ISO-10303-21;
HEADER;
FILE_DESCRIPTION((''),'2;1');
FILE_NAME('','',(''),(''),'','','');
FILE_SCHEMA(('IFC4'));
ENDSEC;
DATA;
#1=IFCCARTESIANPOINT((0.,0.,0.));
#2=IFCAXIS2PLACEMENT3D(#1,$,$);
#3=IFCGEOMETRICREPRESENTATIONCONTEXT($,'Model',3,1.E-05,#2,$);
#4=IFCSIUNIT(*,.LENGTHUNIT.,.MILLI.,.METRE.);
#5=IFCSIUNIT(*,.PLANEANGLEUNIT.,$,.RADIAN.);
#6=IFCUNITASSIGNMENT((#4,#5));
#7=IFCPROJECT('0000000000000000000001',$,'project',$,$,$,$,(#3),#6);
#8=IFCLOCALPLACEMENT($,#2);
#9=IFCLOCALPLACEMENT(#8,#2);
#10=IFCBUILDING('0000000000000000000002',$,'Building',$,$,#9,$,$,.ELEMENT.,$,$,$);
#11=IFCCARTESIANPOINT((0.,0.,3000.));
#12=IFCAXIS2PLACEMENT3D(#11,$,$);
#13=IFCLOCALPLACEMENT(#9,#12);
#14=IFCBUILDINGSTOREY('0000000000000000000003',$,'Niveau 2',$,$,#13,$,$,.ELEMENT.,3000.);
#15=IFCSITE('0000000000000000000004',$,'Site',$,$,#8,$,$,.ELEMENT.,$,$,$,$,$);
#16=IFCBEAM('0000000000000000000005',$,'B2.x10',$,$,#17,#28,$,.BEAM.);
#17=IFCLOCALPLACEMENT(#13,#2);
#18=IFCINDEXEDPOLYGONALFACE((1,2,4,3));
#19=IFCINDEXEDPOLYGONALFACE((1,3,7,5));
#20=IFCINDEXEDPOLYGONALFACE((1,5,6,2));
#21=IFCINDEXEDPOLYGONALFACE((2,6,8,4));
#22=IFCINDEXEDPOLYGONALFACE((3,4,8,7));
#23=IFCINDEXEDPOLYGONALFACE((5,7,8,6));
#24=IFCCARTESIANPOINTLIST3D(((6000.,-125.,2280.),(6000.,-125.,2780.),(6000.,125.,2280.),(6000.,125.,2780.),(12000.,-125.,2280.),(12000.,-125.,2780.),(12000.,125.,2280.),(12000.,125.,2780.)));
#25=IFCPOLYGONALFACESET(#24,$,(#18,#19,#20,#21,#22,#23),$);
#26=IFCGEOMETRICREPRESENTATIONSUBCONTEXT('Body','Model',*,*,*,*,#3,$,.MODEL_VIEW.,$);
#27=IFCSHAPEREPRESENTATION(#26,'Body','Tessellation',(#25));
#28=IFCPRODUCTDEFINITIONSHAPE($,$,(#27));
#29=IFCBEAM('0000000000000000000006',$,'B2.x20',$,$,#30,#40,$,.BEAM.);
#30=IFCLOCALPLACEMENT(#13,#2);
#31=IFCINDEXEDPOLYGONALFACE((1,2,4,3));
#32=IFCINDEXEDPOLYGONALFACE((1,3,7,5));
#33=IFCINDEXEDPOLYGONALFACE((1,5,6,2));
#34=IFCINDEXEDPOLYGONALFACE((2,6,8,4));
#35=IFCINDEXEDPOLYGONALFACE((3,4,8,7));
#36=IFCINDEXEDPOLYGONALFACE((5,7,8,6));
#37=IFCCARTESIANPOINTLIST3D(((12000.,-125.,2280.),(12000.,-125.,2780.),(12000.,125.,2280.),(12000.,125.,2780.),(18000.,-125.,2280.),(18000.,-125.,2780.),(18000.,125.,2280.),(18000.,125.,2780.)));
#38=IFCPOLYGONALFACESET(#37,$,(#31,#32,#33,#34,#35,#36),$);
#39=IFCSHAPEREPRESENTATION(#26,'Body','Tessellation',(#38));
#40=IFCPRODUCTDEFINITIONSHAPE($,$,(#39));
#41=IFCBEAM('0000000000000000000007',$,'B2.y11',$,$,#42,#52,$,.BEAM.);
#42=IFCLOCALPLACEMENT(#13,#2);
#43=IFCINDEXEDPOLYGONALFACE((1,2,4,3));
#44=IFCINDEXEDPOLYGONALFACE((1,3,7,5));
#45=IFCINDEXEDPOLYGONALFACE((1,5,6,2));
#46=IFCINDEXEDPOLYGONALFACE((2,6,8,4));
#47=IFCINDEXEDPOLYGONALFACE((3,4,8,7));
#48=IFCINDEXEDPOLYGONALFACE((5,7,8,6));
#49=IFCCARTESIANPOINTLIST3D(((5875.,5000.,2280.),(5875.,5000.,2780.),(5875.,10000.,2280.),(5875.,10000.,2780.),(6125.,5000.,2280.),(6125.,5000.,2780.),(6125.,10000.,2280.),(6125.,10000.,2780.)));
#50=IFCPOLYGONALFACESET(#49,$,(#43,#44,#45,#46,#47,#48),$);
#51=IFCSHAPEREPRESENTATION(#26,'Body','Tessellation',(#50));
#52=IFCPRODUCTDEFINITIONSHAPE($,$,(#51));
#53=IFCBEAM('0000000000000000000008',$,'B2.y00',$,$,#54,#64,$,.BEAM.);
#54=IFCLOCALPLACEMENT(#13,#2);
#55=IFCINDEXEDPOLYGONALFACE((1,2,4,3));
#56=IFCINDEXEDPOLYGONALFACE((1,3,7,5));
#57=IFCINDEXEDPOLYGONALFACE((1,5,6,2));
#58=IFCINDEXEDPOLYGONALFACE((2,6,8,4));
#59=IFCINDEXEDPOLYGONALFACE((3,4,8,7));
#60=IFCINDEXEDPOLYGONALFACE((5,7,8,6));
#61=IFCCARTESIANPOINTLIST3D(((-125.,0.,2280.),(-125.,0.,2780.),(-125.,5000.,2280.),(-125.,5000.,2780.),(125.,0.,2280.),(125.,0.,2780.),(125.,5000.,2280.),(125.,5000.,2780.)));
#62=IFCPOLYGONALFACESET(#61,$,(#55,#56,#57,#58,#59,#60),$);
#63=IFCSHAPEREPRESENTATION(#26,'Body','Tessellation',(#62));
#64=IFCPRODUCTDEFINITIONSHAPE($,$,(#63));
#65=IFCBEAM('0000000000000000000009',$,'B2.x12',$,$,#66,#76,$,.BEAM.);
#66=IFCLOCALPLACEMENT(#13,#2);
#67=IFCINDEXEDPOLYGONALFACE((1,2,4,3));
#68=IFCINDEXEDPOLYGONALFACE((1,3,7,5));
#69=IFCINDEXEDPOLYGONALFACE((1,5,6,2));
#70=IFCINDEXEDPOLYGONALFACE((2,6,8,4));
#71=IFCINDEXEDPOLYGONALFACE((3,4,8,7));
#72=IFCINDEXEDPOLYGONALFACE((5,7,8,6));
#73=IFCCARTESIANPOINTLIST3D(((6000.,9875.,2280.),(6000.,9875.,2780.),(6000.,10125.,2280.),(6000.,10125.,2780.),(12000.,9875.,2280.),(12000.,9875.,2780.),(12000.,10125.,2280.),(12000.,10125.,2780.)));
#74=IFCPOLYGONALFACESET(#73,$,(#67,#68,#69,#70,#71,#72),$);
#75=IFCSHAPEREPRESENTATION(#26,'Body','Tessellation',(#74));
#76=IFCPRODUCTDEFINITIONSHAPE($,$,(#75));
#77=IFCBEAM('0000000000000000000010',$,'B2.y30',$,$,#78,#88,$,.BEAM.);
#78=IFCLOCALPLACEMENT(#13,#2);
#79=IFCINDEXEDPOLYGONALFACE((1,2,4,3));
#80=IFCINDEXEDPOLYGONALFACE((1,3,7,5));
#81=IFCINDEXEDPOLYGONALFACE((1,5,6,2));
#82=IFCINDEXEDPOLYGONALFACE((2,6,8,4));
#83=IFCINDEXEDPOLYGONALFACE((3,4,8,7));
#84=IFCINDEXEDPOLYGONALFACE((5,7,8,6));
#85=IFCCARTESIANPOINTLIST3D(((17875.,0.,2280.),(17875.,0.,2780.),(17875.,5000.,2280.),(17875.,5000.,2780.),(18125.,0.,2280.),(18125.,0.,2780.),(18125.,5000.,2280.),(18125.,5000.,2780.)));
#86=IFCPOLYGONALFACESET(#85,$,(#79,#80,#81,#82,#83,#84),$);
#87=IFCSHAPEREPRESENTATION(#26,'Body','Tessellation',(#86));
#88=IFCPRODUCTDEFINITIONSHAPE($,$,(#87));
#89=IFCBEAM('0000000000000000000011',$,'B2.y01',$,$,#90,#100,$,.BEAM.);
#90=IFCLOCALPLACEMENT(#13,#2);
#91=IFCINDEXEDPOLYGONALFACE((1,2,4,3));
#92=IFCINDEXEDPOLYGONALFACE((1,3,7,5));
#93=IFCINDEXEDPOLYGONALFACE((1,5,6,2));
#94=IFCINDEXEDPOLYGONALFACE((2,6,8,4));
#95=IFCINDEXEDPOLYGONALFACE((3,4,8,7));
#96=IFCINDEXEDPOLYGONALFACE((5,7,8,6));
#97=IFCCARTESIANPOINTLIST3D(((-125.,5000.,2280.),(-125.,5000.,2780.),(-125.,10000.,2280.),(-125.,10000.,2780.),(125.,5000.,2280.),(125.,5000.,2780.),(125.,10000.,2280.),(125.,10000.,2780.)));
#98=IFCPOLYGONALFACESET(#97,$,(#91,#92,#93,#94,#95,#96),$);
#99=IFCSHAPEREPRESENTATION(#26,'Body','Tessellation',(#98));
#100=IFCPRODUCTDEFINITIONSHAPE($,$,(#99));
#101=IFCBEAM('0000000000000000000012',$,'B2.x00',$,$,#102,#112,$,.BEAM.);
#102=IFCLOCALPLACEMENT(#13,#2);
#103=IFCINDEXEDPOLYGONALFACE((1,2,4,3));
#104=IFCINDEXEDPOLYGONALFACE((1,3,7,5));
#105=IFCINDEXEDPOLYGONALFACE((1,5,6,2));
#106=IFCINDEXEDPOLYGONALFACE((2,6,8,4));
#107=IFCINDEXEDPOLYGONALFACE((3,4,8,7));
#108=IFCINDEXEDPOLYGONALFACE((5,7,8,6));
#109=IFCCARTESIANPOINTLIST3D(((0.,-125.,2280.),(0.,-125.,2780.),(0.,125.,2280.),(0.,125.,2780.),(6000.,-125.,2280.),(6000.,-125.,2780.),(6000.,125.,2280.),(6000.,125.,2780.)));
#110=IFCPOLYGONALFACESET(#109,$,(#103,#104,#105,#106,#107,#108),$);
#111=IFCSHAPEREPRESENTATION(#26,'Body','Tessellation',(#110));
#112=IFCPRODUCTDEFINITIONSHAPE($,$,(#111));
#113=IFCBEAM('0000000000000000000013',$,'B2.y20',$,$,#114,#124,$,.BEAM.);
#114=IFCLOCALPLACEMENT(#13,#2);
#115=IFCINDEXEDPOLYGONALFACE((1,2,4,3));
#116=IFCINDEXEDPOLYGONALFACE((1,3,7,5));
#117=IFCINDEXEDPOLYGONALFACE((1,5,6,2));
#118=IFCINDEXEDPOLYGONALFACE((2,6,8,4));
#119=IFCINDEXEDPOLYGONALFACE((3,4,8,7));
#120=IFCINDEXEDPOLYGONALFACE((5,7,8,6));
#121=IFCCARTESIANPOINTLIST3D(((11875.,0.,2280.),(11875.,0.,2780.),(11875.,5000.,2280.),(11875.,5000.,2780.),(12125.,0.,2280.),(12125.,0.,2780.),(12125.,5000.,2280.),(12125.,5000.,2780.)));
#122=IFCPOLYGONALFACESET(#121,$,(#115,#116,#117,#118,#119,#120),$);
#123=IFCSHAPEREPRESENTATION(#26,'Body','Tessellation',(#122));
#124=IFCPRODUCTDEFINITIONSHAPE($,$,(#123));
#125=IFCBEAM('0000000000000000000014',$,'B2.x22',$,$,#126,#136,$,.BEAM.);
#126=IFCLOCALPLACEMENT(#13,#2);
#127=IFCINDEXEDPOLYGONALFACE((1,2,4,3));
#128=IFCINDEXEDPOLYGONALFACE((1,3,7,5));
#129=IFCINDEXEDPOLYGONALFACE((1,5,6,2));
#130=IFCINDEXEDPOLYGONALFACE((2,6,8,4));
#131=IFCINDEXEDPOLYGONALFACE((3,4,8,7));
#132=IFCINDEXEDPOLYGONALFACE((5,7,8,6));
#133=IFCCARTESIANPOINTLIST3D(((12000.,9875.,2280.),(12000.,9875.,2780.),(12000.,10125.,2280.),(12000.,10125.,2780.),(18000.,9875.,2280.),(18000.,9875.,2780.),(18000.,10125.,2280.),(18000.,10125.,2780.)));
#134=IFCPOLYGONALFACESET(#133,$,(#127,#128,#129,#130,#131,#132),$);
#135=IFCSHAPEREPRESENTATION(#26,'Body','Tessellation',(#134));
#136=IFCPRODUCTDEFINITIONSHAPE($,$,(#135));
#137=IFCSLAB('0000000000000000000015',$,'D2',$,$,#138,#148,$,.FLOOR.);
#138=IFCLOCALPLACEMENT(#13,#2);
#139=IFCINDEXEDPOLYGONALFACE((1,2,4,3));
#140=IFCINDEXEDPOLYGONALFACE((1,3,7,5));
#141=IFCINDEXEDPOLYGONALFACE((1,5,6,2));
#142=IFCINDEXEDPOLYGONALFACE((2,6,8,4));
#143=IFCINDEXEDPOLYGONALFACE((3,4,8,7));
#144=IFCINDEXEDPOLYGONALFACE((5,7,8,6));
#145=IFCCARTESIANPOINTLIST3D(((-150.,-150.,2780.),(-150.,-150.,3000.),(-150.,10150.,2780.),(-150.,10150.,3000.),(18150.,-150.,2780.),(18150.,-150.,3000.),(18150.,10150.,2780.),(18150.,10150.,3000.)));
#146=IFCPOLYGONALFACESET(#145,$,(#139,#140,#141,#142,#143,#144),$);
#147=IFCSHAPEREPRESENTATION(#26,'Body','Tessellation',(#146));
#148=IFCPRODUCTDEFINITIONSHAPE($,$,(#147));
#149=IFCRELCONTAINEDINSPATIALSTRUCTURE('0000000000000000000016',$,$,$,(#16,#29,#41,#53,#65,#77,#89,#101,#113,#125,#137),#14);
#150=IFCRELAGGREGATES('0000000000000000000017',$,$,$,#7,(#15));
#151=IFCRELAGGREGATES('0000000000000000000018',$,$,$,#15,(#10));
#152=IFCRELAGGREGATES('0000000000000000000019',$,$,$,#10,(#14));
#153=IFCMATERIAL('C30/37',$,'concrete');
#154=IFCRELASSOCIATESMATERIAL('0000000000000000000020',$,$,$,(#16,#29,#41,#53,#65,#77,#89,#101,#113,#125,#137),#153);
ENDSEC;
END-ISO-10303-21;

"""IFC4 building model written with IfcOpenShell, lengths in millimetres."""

from ifc_helpers import new_model, si_unit, frame, origin, place, context, subcontext, project, spatial, polyline, rectangle, outline, extrude, material, element, save


model = new_model("IFC4")

# Units and contexts
model_context = context("Model", 3, precision=1e-05, world=origin())
body_context = subcontext(model_context, "Body", "Model", "MODEL_VIEW")
ifc_project = project(units=[si_unit("LENGTHUNIT", "METRE", prefix="MILLI"), si_unit("PLANEANGLEUNIT", "RADIAN")], contexts=[model_context])

# Site, building, storey
site_placement = place(None, origin())
site = spatial("IfcSite", under=ifc_project, at=site_placement, Name="Site", CompositionType="ELEMENT")
building_placement = place(site_placement, origin())
building = spatial("IfcBuilding", under=site, at=building_placement, Name="Building", CompositionType="ELEMENT")
storey_placement = place(building_placement, frame((0.0, 0.0, 3000.0)))
storey = spatial("IfcBuildingStorey", under=building, at=storey_placement, Name="Niveau 2", CompositionType="ELEMENT", Elevation=3000.0)

# Shared definitions
ifc_material = material(Name="C30/37", Category="concrete")

# Beams
for number, where, z_axis, x_axis, name in (
    (1, (6000.0, 0.0, 2530.0), (1.0, 0.0, 0.0), (0.0, 1.0, 0.0), "B2.x10"),
    (2, (12000.0, 0.0, 2530.0), (1.0, 0.0, 0.0), (0.0, 1.0, 0.0), "B2.x20"),
):
    element("IfcBeam", number, at=place(storey_placement, frame(where, z_axis=z_axis, x_axis=x_axis)), inside=storey, material=ifc_material, Name=name, PredefinedType="BEAM", context=body_context, shape_type="SweptSolid", body=[
        extrude(rectangle(XDim=250.0, YDim=500.0), origin(), (0.0, 0.0, 1.0), 6000.0),
    ])
for number, where, z_axis, x_axis, name in (
    (3, (6000.0, 5000.0, 2530.0), (0.0, 1.0, 0.0), (-1.0, 0.0, 0.0), "B2.y11"),
    (4, (0.0, 0.0, 2530.0), (0.0, 1.0, 0.0), (-1.0, 0.0, 0.0), "B2.y00"),
):
    element("IfcBeam", number, at=place(storey_placement, frame(where, z_axis=z_axis, x_axis=x_axis)), inside=storey, material=ifc_material, Name=name, PredefinedType="BEAM", context=body_context, shape_type="SweptSolid", body=[
        extrude(rectangle(XDim=250.0, YDim=500.0), origin(), (0.0, 0.0, 1.0), 5000.0),
    ])
beam_1_placement = place(storey_placement, frame((6000.0, 10000.0, 2530.0), z_axis=(1.0, 0.0, 0.0), x_axis=(0.0, 1.0, 0.0)))
element("IfcBeam", 5, at=beam_1_placement, inside=storey, material=ifc_material, Name="B2.x12", PredefinedType="BEAM", context=body_context, shape_type="SweptSolid", body=[
    extrude(rectangle(XDim=250.0, YDim=500.0), origin(), (0.0, 0.0, 1.0), 6000.0),
])
for number, where, z_axis, x_axis, name in (
    (6, (18000.0, 0.0, 2530.0), (0.0, 1.0, 0.0), (-1.0, 0.0, 0.0), "B2.y30"),
    (7, (0.0, 5000.0, 2530.0), (0.0, 1.0, 0.0), (-1.0, 0.0, 0.0), "B2.y01"),
):
    element("IfcBeam", number, at=place(storey_placement, frame(where, z_axis=z_axis, x_axis=x_axis)), inside=storey, material=ifc_material, Name=name, PredefinedType="BEAM", context=body_context, shape_type="SweptSolid", body=[
        extrude(rectangle(XDim=250.0, YDim=500.0), origin(), (0.0, 0.0, 1.0), 5000.0),
    ])
beam_2_placement = place(storey_placement, frame((0.0, 0.0, 2530.0), z_axis=(1.0, 0.0, 0.0), x_axis=(0.0, 1.0, 0.0)))
element("IfcBeam", 8, at=beam_2_placement, inside=storey, material=ifc_material, Name="B2.x00", PredefinedType="BEAM", context=body_context, shape_type="SweptSolid", body=[
    extrude(rectangle(XDim=250.0, YDim=500.0), origin(), (0.0, 0.0, 1.0), 6000.0),
])
beam_3_placement = place(storey_placement, frame((12000.0, 0.0, 2530.0), z_axis=(0.0, 1.0, 0.0), x_axis=(-1.0, 0.0, 0.0)))
element("IfcBeam", 9, at=beam_3_placement, inside=storey, material=ifc_material, Name="B2.y20", PredefinedType="BEAM", context=body_context, shape_type="SweptSolid", body=[
    extrude(rectangle(XDim=250.0, YDim=500.0), origin(), (0.0, 0.0, 1.0), 5000.0),
])
beam_4_placement = place(storey_placement, frame((12000.0, 10000.0, 2530.0), z_axis=(1.0, 0.0, 0.0), x_axis=(0.0, 1.0, 0.0)))
element("IfcBeam", 10, at=beam_4_placement, inside=storey, material=ifc_material, Name="B2.x22", PredefinedType="BEAM", context=body_context, shape_type="SweptSolid", body=[
    extrude(rectangle(XDim=250.0, YDim=500.0), origin(), (0.0, 0.0, 1.0), 6000.0),
])

# Slab
slab_placement = place(storey_placement, frame((0.0, 0.0, 2780.0), z_axis=(0.0, 0.0, 1.0), x_axis=(1.0, 0.0, 0.0)))
element("IfcSlab", 11, at=slab_placement, inside=storey, material=ifc_material, Name="D2", PredefinedType="FLOOR", context=body_context, shape_type="SweptSolid", body=[
    extrude(outline(polyline([(-150.0, -150.0), (18150.0, -150.0), (18150.0, 10150.0), (-150.0, 10150.0), (-150.0, -150.0)])), origin(), (0.0, 0.0, 1.0), 220.0),
])

save(model, "model.ifc")
